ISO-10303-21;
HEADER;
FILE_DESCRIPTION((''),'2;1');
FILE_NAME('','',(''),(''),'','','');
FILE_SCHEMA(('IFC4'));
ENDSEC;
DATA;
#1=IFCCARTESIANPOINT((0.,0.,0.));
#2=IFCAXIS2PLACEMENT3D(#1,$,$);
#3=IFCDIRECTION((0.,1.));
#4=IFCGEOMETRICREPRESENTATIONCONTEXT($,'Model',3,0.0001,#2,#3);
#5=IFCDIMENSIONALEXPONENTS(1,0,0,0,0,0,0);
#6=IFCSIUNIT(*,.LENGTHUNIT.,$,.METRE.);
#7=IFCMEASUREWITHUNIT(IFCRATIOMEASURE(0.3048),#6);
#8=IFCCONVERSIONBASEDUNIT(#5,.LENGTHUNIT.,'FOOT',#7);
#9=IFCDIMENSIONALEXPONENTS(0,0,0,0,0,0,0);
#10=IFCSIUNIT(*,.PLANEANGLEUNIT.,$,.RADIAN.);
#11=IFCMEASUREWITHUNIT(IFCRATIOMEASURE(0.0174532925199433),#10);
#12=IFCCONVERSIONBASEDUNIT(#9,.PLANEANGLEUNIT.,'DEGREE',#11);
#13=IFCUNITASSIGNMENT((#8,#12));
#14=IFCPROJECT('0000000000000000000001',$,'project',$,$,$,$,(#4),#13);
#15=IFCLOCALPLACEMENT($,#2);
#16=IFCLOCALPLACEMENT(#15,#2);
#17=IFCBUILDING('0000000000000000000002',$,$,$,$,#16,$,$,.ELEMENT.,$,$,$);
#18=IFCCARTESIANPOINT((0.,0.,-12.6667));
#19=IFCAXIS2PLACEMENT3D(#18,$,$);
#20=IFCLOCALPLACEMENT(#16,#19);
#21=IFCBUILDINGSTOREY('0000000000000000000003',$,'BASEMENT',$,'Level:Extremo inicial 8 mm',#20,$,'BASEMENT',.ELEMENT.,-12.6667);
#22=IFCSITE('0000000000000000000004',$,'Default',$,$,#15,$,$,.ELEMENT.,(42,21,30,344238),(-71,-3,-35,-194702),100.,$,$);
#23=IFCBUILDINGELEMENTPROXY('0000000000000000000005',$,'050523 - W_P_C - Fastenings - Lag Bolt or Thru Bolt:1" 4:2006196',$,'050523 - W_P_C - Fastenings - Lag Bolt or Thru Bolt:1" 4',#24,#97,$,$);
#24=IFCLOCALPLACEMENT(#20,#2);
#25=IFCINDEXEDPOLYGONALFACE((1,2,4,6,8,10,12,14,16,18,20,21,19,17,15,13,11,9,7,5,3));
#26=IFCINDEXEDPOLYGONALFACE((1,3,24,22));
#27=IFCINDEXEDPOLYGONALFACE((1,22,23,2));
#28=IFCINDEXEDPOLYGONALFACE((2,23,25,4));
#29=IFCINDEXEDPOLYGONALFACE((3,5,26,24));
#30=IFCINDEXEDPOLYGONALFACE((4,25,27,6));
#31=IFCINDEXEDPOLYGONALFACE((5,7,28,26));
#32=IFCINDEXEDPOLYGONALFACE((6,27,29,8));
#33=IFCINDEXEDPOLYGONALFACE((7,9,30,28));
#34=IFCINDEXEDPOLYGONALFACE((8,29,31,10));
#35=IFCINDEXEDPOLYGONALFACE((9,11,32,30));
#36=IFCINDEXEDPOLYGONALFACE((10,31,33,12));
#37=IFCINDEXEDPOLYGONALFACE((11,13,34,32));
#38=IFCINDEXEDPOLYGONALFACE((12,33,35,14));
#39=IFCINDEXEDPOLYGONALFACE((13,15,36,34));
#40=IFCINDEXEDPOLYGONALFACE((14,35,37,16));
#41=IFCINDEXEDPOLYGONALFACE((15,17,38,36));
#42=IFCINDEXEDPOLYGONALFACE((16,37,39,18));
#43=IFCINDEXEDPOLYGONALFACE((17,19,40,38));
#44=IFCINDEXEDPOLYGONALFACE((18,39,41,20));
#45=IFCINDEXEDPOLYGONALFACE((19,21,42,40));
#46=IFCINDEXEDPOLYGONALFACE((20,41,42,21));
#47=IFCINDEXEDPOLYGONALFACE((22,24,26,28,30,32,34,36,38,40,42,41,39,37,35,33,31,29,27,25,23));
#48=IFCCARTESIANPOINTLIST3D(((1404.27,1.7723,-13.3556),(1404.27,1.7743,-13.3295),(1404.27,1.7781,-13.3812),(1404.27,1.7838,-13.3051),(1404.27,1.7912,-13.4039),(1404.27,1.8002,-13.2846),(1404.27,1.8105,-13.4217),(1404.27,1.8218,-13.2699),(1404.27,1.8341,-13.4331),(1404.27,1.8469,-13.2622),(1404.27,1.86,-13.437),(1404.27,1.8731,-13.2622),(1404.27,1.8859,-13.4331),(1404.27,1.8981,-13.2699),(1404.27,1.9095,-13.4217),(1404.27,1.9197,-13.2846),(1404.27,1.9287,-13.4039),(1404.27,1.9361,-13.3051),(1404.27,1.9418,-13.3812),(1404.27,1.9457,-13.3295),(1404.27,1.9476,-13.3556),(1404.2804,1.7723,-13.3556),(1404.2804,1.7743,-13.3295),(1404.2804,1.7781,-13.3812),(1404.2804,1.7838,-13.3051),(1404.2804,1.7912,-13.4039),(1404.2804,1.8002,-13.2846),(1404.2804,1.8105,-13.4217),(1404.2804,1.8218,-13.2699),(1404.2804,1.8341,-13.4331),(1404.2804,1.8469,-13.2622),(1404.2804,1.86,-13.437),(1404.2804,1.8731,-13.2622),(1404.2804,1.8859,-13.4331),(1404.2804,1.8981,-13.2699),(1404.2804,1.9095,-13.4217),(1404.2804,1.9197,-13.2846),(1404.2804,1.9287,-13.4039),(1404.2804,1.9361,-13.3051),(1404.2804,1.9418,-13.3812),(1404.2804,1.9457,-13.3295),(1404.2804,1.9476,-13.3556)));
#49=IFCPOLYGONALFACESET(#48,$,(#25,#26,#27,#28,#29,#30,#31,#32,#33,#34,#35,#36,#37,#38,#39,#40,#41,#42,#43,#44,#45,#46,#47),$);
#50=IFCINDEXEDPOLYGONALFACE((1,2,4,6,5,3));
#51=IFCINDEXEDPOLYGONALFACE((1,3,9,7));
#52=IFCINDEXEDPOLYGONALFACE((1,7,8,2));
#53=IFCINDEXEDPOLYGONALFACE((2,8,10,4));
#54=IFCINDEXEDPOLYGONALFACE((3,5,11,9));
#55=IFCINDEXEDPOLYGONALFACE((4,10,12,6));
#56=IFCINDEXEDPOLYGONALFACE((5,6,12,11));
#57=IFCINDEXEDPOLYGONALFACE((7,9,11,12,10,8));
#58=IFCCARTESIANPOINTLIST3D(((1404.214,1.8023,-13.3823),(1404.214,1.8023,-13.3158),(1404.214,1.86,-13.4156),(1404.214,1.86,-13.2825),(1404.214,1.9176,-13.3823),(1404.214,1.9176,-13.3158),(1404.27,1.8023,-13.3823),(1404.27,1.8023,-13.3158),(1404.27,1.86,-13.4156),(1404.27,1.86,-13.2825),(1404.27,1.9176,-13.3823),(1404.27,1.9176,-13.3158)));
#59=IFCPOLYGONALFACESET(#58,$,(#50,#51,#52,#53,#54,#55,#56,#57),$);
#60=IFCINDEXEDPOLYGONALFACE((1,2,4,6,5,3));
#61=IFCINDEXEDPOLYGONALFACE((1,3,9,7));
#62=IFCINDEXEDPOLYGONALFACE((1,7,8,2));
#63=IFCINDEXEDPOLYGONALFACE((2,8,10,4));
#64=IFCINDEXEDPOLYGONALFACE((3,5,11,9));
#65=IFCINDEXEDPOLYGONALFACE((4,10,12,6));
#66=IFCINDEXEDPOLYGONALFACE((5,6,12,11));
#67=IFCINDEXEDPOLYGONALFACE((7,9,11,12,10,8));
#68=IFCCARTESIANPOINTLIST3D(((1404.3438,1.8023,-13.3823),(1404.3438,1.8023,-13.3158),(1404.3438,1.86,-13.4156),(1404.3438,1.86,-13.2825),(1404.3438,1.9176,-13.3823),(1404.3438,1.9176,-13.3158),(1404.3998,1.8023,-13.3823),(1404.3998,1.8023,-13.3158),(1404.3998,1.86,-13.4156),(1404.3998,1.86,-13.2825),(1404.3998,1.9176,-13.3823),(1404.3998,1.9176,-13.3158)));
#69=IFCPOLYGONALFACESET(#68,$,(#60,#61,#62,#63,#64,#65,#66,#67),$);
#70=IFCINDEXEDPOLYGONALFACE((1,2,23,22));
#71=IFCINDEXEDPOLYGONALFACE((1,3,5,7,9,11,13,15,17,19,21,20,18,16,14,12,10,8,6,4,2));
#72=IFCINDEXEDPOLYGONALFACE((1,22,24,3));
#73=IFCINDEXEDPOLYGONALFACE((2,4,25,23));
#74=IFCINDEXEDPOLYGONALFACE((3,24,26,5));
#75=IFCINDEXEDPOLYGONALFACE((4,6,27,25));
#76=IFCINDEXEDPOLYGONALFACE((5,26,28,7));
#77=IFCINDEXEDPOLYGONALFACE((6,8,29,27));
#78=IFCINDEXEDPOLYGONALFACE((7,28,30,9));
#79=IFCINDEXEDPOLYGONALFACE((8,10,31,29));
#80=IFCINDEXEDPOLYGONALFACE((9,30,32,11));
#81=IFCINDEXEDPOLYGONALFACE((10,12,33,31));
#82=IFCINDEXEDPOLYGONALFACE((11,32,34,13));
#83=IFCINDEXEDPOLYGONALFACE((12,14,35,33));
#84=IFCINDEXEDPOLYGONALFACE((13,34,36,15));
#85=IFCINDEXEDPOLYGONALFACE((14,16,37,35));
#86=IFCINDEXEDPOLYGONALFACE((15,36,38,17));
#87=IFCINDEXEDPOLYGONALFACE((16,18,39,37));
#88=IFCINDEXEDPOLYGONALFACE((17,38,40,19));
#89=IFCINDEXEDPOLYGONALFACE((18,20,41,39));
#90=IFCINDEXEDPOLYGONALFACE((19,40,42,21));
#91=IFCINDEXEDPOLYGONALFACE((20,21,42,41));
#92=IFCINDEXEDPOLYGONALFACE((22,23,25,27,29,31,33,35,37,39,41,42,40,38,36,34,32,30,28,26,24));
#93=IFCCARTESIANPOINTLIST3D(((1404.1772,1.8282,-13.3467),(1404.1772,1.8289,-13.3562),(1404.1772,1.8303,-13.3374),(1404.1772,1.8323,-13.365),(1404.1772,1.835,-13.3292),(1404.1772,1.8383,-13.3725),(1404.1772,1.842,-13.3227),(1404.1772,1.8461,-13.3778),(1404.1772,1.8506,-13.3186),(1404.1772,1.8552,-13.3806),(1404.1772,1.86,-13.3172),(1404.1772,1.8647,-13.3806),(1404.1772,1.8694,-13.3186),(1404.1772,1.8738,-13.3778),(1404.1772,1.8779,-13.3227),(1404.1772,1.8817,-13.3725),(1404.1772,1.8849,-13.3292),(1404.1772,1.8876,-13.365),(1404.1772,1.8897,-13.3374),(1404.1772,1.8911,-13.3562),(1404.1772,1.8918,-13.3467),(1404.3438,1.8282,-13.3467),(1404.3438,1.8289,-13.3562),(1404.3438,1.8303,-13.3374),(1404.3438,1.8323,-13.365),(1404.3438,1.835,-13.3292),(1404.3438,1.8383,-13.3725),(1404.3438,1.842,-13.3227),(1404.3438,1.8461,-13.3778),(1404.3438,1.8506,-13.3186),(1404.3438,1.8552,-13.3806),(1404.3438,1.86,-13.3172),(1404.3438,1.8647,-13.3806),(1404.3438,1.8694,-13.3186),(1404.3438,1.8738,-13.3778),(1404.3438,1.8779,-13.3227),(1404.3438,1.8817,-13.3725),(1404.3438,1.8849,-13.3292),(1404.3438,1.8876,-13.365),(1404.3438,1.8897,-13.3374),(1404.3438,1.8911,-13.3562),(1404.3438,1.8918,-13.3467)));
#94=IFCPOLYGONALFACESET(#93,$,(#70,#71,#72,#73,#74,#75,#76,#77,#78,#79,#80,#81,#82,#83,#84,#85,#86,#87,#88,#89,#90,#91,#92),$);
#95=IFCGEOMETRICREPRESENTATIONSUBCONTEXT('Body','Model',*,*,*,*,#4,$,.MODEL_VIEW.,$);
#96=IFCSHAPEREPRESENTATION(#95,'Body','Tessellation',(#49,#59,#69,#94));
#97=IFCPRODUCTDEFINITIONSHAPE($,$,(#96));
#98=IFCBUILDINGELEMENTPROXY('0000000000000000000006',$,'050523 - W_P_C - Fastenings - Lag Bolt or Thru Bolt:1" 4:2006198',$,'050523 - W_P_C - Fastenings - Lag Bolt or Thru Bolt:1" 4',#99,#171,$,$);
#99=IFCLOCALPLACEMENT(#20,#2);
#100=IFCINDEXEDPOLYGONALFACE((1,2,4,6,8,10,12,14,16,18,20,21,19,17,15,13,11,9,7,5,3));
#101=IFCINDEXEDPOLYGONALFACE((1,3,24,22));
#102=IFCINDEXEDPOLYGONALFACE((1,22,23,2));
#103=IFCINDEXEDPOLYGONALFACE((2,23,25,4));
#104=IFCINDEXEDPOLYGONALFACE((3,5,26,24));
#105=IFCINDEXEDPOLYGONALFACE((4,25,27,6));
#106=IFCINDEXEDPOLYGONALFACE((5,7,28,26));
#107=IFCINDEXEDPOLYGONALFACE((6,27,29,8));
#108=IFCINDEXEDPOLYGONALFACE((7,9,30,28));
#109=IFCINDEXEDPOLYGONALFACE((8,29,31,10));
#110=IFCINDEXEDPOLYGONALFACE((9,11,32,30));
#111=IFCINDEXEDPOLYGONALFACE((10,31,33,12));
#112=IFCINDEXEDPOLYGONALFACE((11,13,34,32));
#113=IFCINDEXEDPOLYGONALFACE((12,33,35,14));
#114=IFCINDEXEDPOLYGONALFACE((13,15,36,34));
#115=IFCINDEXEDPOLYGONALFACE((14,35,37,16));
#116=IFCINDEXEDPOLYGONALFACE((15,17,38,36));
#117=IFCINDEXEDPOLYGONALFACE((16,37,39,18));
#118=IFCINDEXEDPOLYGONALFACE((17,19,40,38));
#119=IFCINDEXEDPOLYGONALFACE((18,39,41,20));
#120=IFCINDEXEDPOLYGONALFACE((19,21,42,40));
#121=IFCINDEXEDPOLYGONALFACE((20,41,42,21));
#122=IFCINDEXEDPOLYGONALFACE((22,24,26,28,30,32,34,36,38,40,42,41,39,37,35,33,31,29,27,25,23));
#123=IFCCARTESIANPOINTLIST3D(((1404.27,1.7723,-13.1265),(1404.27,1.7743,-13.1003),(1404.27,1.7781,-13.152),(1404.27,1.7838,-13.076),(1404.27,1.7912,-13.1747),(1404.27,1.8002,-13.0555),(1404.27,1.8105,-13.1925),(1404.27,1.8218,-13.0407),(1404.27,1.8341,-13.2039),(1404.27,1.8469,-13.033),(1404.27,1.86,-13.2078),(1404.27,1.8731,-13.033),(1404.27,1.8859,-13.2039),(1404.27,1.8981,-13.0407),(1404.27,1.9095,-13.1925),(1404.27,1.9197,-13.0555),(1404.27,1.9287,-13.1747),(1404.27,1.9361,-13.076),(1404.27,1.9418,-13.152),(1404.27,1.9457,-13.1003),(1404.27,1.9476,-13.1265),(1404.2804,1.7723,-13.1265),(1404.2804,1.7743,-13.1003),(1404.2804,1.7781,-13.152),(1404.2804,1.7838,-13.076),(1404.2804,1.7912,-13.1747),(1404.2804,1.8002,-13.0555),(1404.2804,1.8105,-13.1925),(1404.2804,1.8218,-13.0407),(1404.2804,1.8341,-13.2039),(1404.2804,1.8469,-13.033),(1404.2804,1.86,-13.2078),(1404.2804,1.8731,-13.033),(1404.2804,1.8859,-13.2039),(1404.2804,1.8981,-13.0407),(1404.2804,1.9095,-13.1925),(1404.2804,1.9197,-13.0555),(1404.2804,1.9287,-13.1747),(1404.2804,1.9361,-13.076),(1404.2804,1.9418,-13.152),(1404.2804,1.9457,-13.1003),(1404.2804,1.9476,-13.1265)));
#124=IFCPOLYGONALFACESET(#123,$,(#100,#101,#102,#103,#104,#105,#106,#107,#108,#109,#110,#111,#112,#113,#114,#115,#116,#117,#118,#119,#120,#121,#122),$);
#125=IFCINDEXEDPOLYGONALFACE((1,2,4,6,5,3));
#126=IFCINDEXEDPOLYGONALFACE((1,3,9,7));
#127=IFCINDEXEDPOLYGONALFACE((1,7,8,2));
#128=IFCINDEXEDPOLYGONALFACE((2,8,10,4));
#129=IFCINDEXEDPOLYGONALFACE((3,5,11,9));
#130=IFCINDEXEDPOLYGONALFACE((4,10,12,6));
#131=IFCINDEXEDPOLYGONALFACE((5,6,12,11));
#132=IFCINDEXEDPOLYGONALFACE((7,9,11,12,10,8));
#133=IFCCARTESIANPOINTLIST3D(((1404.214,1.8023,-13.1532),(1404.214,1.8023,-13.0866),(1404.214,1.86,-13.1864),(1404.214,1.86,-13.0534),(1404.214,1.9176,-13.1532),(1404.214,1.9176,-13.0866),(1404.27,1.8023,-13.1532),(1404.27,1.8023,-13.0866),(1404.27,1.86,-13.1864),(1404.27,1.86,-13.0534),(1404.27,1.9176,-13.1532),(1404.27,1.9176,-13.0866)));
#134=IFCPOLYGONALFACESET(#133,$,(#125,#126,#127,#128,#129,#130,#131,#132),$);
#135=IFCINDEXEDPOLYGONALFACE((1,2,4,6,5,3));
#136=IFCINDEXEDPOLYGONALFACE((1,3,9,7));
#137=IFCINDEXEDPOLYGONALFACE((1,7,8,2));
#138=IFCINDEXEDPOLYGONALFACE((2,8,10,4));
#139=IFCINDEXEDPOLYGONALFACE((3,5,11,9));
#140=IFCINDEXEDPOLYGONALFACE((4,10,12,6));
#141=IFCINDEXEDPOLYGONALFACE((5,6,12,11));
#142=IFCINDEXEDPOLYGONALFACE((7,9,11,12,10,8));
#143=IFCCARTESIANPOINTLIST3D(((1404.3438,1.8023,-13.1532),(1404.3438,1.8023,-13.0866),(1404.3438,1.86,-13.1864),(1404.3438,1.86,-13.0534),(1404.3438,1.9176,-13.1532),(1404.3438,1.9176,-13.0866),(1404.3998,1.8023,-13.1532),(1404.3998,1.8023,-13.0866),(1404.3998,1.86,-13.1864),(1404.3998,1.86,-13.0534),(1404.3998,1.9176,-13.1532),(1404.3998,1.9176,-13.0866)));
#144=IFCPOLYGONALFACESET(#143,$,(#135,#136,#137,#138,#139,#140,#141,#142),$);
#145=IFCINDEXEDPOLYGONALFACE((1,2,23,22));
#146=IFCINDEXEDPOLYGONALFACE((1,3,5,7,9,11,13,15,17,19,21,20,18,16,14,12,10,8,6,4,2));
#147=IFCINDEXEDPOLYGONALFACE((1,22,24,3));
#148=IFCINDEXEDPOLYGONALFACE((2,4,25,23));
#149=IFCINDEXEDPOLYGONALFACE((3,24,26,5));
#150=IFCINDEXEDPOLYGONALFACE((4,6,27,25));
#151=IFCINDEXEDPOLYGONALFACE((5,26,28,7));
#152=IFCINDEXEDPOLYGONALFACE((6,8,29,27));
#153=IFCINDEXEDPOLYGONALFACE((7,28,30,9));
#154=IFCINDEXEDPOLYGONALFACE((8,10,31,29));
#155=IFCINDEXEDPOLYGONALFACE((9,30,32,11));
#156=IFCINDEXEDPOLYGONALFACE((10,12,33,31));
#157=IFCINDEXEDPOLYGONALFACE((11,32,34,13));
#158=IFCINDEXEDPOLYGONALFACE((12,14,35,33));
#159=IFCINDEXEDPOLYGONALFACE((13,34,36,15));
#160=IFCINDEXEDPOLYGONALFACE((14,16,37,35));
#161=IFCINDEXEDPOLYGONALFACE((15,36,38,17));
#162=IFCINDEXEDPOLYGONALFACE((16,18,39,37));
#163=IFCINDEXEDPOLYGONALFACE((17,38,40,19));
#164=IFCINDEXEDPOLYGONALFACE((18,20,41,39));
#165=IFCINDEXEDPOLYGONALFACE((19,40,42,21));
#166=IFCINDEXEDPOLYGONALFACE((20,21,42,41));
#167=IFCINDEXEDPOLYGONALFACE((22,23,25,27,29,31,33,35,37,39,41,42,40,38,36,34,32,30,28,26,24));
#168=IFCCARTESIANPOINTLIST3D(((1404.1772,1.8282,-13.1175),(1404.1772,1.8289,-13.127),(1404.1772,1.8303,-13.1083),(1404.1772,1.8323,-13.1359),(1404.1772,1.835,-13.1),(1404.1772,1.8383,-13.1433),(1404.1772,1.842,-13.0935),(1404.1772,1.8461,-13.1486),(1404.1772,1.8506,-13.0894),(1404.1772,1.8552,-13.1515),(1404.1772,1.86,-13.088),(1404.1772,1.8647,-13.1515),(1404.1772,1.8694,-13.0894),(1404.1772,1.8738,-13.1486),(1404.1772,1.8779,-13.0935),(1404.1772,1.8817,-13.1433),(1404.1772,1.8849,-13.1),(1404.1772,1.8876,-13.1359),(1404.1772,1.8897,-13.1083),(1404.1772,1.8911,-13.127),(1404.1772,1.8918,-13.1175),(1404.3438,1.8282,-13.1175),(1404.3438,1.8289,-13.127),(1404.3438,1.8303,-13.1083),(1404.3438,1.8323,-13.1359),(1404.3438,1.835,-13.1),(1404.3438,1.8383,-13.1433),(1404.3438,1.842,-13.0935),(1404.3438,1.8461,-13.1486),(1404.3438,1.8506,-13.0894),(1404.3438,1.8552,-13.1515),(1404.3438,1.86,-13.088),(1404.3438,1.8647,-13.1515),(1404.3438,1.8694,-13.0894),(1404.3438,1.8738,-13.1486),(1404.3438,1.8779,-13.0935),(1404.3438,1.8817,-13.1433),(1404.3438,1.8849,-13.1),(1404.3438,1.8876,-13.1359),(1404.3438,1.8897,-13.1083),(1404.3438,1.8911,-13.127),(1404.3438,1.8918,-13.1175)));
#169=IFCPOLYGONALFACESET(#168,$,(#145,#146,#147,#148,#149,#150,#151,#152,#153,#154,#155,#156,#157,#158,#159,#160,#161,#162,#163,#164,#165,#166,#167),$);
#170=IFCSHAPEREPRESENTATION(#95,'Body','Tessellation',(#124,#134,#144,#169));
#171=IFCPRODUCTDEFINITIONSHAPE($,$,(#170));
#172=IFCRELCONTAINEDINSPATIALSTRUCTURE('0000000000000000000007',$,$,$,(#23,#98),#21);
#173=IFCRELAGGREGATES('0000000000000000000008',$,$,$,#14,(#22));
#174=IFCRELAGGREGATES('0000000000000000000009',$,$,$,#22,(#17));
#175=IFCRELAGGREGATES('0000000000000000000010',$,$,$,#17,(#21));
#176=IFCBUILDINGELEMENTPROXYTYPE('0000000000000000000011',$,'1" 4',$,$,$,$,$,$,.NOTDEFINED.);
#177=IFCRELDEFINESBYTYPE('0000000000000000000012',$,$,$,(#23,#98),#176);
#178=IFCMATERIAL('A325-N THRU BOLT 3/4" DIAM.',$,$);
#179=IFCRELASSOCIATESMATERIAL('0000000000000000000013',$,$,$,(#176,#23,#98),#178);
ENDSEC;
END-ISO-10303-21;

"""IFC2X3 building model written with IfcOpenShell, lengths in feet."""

from ifc_helpers import new_model, entity, si_unit, converted_unit, direction, frame, frame_2d, origin, place, context, subcontext, project, spatial, polyline, circle, outline, extrude, source, transform, mapped, material, type_object, type_shapes, element, save


model = new_model("IFC2X3")

# Units and contexts
model_context = context("Model", 3, precision=0.0001, world=origin(), true_north=direction((0.0, 1.0)))
body_context = subcontext(model_context, "Body", "Model", "MODEL_VIEW")
ifc_project = project(units=[converted_unit("LENGTHUNIT", "FOOT", entity("IfcRatioMeasure", 0.3048), si_unit("LENGTHUNIT", "METRE"), dimensions=[1, 0, 0, 0, 0, 0, 0]), converted_unit("PLANEANGLEUNIT", "DEGREE", entity("IfcRatioMeasure", 0.0174532925199433), si_unit("PLANEANGLEUNIT", "RADIAN"), dimensions=[0, 0, 0, 0, 0, 0, 0])], contexts=[model_context])

# Site, building, storey
site_placement = place(None, origin())
site = spatial("IfcSite", under=ifc_project, at=site_placement, Name="Default", CompositionType="ELEMENT", RefLatitude=(42, 21, 30, 344238), RefLongitude=(-71, -3, -35, -194702), RefElevation=100.0)
building_placement = place(site_placement, origin())
building = spatial("IfcBuilding", under=site, at=building_placement, CompositionType="ELEMENT")
storey_placement = place(building_placement, frame((0.0, 0.0, -12.6667)))
storey = spatial("IfcBuildingStorey", under=building, at=storey_placement, Name="BASEMENT", ObjectType="Level:Extremo inicial 8 mm", LongName="BASEMENT", CompositionType="ELEMENT", Elevation=-12.6667)

# Building element proxies
ifc_material_1 = material(Name="A325-N THRU BOLT 3/4\" DIAM.")
building_element_proxy_type_1 = type_object("IfcBuildingElementProxyType", Name="1\" 4", PredefinedType="NOTDEFINED", material=ifc_material_1)
shared_shape_1 = source(origin(), body_context, "Body", "SweptSolid", [
    extrude(circle(Radius=0.0879, at=frame_2d((0.0, 0.0), x_axis=(1.0, 0.0))), frame((0.0, 0.0, -0.0738), z_axis=(0.0, 0.0, 1.0), x_axis=(0.0, -1.0, 0.0)), (0.0, 0.0, 1.0), 0.0104),
    extrude(outline(polyline([(-0.0333, -0.0576), (0.0333, -0.0576), (0.0665, 0.0), (0.0333, 0.0576), (-0.0333, 0.0576), (-0.0665, 0.0), (-0.0333, -0.0576)])), frame((0.0, 0.0, -0.1298), z_axis=(0.0, 0.0, 1.0), x_axis=(0.866025, -0.5, 0.0)), (0.0, 0.0, 1.0), 0.056),
    extrude(outline(polyline([(-0.0333, -0.0576), (0.0333, -0.0576), (0.0665, 0.0), (0.0333, 0.0576), (-0.0333, 0.0576), (-0.0665, 0.0), (-0.0333, -0.0576)])), frame((0.0, 0.0, 0.0), z_axis=(0.0, 0.0, 1.0), x_axis=(0.0, -1.0, 0.0)), (0.0, 0.0, 1.0), 0.056),
    extrude(circle(Radius=0.0319, at=frame_2d((0.0, 0.0), x_axis=(1.0, 0.0))), frame((0.0, 0.0, -0.1667), z_axis=(0.0, 0.0, 1.0), x_axis=(0.0, 1.0, 0.0)), (0.0, 0.0, 1.0), 0.1667),
])
type_shapes(building_element_proxy_type_1, [shared_shape_1])
for number, where, z_axis, x_axis, name in (
    (1, (1404.3438, 1.86, -13.3491), (1.0, 0.0, 0.0), (0.0, 1.0, 0.0), "050523 - W_P_C - Fastenings - Lag Bolt or Thru Bolt:1\" 4:2006196"),
    (2, (1404.3438, 1.86, -13.1199), (1.0, 0.0, 0.0), (0.0, 1.0, 0.0), "050523 - W_P_C - Fastenings - Lag Bolt or Thru Bolt:1\" 4:2006198"),
):
    element("IfcBuildingElementProxy", number, at=place(storey_placement, frame(where, z_axis=z_axis, x_axis=x_axis)), inside=storey, type_object=building_element_proxy_type_1, material=ifc_material_1, Name=name, ObjectType="050523 - W_P_C - Fastenings - Lag Bolt or Thru Bolt:1\" 4", context=body_context, shape_type="MappedRepresentation", body=[
        mapped(shared_shape_1, transform((0.0, 0.0, 0.0), scale=1.0)),
    ])

save(model, "model.ifc")
